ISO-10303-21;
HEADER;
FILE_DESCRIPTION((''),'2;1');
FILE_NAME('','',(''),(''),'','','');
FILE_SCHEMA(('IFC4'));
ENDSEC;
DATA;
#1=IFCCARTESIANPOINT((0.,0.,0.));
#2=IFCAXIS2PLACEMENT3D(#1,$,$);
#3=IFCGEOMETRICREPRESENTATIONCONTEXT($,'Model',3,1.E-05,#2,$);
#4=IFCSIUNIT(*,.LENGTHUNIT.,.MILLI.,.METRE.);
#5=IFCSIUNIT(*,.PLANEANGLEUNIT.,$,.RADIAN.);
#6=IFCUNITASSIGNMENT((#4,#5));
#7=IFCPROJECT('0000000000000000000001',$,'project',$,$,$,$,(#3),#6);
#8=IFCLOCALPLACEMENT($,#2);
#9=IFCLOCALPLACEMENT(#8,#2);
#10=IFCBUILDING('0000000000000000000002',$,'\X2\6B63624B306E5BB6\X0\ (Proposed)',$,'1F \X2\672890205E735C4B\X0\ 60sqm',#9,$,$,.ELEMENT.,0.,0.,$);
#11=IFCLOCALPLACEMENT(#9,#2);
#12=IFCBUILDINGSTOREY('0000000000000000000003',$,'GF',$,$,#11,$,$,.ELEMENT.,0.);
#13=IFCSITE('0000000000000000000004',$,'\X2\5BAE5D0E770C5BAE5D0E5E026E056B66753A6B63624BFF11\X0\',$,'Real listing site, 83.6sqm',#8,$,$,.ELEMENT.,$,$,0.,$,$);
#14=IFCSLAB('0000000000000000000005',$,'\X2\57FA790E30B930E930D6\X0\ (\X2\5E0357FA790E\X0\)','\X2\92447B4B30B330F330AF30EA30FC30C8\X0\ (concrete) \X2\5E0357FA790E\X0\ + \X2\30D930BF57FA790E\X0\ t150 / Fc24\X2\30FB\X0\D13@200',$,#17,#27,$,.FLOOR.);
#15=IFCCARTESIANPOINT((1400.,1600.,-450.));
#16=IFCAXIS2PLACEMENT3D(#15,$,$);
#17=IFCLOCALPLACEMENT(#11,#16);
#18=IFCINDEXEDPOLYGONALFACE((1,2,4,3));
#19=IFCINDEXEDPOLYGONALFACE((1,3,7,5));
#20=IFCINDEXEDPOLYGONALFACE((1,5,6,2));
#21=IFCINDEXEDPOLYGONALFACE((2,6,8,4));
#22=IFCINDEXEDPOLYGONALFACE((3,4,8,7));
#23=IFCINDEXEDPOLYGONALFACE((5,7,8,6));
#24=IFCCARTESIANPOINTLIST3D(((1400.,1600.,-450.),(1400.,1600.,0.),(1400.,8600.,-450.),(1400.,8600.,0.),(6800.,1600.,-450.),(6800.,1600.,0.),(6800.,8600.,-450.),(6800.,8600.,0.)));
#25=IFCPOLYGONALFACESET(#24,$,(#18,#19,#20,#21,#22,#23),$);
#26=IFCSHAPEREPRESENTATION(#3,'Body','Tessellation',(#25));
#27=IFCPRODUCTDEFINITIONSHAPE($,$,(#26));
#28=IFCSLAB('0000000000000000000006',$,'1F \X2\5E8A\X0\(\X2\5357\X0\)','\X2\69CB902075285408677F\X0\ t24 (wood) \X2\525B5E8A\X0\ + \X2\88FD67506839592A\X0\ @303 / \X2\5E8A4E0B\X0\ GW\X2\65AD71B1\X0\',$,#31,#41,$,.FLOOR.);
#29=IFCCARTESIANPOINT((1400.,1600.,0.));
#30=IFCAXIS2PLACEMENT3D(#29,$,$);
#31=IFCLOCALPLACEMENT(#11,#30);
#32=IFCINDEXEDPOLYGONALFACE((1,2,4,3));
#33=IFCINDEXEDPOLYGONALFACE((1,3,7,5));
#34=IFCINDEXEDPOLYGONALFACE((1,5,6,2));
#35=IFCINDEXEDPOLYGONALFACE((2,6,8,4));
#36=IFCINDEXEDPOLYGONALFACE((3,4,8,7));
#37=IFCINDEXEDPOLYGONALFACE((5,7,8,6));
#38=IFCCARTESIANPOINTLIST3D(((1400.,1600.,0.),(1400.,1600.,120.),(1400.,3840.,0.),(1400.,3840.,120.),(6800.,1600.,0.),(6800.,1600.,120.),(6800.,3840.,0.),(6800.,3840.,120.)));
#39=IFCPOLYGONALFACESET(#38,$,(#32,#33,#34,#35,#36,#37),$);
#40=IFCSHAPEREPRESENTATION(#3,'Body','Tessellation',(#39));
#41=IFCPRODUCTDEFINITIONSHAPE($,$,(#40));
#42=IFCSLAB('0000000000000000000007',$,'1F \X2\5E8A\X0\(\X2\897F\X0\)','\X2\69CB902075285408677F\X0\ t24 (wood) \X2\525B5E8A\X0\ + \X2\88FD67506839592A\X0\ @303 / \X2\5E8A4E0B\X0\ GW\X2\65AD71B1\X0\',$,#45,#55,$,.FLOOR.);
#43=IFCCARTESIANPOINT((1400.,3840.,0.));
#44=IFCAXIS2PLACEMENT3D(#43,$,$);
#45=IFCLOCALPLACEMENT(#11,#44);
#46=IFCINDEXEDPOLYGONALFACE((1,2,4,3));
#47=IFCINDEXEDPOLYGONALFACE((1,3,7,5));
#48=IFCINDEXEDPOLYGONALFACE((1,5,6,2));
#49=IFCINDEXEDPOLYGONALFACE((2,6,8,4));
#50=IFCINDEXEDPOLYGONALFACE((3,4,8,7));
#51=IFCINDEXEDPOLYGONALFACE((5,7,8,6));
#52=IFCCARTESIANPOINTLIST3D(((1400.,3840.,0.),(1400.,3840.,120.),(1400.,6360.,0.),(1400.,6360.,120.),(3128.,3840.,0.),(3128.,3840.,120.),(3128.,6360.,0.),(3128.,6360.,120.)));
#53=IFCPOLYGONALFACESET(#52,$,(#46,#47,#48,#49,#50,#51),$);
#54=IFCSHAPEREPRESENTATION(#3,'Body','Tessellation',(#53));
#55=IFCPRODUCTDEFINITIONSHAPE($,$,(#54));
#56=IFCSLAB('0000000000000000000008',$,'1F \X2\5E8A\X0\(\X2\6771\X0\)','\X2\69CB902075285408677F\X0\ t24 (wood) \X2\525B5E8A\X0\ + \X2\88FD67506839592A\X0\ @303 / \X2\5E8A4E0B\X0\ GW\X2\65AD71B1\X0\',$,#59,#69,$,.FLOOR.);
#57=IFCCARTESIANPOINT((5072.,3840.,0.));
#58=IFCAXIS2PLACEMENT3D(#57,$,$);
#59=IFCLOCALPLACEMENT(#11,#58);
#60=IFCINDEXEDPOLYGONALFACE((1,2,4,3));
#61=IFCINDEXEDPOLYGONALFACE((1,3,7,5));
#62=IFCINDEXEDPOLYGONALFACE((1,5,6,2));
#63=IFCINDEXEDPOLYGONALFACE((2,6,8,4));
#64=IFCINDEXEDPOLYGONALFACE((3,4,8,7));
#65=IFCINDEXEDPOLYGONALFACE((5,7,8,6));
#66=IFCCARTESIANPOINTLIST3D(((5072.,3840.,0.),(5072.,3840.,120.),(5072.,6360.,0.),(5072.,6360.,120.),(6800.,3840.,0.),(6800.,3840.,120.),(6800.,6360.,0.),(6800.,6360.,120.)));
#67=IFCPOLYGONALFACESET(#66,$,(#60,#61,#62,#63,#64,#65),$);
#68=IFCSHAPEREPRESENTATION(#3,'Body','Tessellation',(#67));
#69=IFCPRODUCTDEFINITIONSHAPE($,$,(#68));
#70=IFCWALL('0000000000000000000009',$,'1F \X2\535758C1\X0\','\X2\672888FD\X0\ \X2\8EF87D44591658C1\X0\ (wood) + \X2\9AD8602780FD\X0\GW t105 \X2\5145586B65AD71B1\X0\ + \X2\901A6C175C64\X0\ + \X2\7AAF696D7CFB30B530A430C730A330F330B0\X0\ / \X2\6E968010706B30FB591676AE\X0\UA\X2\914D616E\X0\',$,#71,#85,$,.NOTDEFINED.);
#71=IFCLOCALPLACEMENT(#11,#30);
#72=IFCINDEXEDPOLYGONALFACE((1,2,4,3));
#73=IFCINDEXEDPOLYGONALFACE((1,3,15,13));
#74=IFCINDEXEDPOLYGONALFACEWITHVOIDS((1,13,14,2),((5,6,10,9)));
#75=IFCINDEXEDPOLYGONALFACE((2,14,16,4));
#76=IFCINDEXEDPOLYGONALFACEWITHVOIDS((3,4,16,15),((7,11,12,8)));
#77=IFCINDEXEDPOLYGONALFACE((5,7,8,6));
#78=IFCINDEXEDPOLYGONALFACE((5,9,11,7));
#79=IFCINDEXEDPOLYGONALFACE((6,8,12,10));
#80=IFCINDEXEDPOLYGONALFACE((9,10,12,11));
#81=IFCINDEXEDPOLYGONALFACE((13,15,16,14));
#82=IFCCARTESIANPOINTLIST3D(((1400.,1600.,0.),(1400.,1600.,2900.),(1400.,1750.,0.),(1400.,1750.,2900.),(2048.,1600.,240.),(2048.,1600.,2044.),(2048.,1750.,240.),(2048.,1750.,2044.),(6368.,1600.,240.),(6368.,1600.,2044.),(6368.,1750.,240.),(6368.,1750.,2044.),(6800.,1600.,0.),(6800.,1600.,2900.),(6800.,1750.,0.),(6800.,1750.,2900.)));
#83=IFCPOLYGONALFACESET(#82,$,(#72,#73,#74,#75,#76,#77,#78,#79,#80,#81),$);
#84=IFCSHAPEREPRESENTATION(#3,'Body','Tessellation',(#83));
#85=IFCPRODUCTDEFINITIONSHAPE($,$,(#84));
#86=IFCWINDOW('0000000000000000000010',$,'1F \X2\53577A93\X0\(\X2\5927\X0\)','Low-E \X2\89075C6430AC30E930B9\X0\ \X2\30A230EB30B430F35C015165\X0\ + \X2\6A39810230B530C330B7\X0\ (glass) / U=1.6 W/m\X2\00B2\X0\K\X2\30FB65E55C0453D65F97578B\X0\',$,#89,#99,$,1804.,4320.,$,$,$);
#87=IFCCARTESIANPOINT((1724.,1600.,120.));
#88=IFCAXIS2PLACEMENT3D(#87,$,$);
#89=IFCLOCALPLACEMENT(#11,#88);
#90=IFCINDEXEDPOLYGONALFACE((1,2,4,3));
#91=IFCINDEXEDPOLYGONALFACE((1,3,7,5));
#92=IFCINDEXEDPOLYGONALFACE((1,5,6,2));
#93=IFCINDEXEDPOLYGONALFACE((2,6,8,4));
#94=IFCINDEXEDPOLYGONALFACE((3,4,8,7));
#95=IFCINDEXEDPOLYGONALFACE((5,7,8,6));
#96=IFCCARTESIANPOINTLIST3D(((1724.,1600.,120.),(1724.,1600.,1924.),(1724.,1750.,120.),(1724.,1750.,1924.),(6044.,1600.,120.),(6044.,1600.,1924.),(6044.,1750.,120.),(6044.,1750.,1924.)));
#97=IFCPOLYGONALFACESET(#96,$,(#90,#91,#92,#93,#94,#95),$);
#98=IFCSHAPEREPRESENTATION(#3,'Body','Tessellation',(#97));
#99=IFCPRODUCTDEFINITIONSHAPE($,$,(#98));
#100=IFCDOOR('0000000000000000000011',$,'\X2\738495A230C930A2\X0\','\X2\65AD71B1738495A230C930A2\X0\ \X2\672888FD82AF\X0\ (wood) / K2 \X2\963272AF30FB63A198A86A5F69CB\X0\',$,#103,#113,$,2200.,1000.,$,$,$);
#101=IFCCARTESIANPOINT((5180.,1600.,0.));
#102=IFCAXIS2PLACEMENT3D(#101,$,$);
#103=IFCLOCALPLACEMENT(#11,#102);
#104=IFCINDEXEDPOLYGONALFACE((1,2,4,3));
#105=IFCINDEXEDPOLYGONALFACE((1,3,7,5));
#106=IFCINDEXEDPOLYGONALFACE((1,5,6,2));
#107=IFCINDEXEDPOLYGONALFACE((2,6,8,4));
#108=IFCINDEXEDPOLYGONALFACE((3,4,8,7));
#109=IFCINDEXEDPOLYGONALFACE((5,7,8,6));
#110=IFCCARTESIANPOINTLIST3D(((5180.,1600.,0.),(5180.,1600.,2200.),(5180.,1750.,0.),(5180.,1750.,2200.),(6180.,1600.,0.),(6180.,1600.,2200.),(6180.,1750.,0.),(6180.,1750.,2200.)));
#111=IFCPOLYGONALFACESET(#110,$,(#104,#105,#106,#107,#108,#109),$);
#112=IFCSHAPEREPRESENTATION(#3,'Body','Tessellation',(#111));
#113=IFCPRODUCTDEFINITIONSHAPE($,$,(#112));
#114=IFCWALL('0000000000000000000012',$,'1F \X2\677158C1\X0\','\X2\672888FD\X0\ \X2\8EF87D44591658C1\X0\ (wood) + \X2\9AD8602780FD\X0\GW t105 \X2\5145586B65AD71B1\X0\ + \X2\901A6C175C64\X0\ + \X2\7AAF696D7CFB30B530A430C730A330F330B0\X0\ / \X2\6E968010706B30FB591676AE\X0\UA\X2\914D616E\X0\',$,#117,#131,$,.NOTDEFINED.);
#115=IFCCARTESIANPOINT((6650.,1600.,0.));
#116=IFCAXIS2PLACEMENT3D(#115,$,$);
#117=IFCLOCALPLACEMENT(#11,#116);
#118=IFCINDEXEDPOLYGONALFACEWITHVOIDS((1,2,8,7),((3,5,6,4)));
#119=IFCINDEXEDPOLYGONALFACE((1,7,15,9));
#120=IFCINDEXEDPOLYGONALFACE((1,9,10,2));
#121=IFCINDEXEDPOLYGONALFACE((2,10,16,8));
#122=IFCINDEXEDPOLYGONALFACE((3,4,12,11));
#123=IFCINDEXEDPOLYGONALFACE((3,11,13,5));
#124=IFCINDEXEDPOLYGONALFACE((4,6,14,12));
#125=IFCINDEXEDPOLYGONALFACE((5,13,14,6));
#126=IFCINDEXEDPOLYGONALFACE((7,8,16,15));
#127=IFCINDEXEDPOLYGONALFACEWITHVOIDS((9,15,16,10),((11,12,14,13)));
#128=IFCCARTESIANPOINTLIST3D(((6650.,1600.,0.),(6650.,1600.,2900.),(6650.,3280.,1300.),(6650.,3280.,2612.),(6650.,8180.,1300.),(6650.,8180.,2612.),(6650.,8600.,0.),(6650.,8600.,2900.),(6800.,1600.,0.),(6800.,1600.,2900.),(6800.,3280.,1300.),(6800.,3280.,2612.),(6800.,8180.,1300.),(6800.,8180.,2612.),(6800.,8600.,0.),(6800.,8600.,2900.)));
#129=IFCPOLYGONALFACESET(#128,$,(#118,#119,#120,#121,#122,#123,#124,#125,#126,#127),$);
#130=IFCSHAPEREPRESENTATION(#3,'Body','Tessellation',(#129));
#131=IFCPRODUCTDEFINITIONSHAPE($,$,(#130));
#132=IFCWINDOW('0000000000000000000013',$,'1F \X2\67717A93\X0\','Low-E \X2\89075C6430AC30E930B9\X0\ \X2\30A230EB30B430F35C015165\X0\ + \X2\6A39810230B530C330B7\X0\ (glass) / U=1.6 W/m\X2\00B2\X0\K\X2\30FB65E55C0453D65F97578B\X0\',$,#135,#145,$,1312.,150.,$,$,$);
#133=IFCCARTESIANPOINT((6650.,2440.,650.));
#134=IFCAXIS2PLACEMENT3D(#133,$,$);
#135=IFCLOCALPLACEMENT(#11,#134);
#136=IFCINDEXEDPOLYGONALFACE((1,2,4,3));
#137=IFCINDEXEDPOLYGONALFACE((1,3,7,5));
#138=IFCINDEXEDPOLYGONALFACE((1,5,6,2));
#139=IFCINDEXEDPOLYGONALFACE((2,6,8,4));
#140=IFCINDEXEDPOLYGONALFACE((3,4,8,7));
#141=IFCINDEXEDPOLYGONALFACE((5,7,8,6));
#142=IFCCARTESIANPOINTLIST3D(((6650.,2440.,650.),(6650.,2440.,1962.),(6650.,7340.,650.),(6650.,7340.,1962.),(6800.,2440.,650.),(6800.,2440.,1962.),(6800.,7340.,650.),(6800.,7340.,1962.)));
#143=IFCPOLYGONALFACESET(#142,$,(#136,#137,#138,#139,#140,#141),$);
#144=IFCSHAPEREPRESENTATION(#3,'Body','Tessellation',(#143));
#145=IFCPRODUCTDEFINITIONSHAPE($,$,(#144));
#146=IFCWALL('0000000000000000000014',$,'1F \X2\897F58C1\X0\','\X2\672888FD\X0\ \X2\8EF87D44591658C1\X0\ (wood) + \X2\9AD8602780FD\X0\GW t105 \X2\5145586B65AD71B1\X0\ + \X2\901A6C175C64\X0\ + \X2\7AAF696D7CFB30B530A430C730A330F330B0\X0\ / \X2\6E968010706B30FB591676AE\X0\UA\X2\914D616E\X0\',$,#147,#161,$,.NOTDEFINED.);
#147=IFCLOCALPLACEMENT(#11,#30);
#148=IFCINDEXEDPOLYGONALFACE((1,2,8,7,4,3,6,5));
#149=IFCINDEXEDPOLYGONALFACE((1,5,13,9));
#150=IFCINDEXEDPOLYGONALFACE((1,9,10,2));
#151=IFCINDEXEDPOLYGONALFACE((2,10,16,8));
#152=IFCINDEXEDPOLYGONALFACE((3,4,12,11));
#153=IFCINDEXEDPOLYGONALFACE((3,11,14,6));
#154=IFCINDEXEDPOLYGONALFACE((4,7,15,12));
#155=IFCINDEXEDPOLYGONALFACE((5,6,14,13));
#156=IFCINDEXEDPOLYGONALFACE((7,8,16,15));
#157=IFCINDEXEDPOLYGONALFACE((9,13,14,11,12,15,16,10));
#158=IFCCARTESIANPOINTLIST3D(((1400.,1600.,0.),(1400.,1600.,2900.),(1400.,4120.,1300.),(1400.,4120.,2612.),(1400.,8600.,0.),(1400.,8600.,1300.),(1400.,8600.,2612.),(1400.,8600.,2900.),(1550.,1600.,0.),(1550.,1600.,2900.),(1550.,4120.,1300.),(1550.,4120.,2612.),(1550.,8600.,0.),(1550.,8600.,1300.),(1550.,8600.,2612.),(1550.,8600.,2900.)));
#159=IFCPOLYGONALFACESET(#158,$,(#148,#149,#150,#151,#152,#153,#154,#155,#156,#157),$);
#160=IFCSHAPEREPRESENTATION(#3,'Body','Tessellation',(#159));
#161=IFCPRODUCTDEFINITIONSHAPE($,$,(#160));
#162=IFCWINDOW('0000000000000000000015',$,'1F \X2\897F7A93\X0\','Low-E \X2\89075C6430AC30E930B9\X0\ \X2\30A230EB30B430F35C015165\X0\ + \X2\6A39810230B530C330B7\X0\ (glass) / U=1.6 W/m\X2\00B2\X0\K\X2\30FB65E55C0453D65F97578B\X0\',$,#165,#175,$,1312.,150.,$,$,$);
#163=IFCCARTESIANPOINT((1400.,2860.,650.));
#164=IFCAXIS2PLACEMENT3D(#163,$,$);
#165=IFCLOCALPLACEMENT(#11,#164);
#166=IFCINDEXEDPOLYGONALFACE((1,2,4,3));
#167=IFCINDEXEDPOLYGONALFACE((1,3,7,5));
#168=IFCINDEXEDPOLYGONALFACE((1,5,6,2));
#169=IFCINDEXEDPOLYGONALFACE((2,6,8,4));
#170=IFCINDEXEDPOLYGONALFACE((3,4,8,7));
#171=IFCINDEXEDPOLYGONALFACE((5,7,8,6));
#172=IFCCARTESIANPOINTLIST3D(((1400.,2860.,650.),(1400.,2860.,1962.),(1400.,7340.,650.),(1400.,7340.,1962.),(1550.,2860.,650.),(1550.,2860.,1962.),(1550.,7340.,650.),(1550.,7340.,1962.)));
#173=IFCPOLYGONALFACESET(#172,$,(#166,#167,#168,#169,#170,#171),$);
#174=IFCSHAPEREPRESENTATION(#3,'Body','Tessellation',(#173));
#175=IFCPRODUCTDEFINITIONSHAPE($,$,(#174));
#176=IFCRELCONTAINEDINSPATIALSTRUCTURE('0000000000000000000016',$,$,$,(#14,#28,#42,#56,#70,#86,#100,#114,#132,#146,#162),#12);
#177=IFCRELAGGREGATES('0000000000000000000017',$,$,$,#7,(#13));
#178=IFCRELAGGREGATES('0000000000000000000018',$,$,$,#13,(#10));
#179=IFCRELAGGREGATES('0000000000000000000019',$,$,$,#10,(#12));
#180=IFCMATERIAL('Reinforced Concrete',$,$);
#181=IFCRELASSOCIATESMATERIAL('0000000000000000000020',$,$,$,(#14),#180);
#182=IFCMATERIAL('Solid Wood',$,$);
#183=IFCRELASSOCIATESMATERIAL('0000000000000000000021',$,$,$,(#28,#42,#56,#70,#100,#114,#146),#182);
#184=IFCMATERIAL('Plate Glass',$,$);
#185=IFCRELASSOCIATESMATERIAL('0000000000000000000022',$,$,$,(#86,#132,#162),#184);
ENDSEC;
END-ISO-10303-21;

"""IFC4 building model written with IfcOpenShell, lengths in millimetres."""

from ifc_helpers import new_model, si_unit, frame, frame_2d, origin, place, context, project, spatial, rectangle, extrude, material, element, fill, save


model = new_model("IFC4")

# Units and contexts
model_context = context("Model", 3, precision=1e-05, world=origin())
ifc_project = project(units=[si_unit("LENGTHUNIT", "METRE", prefix="MILLI"), si_unit("PLANEANGLEUNIT", "RADIAN")], contexts=[model_context])

# Site, building, storey
site_placement = place(None, origin())
site = spatial("IfcSite", under=ifc_project, at=site_placement, Name="宮崎県宮崎市清武町正手１", ObjectType="Real listing site, 83.6sqm", CompositionType="ELEMENT", RefElevation=0.0)
building_placement = place(site_placement, origin())
building = spatial("IfcBuilding", under=site, at=building_placement, Name="正手の家 (Proposed)", ObjectType="1F 木造平屋 60sqm", CompositionType="ELEMENT", ElevationOfRefHeight=0.0, ElevationOfTerrain=0.0)
storey_placement = place(building_placement, origin())
storey = spatial("IfcBuildingStorey", under=building, at=storey_placement, Name="GF", CompositionType="ELEMENT", Elevation=0.0)

# Slabs
ifc_material_1 = material(Name="Reinforced Concrete")
slab_1_placement = place(storey_placement, frame((1400.0, 1600.0, -450.0)))
element("IfcSlab", 1, at=slab_1_placement, inside=storey, material=ifc_material_1, Name="基礎スラブ (布基礎)", Description="鉄筋コンクリート (concrete) 布基礎 + ベタ基礎 t150 / Fc24・D13@200", PredefinedType="FLOOR", context=model_context, shape_type="SweptSolid", body=[
    extrude(rectangle(XDim=5400.0, YDim=7000.0, at=frame_2d((2700.0, 3500.0))), frame((1400.0, 1600.0, -450.0)), (0.0, 0.0, 1.0), 450.0),
])
ifc_material_2 = material(Name="Solid Wood")
slab_2_placement = place(storey_placement, frame((1400.0, 1600.0, 0.0)))
element("IfcSlab", 2, at=slab_2_placement, inside=storey, material=ifc_material_2, Name="1F 床(南)", Description="構造用合板 t24 (wood) 剛床 + 製材根太 @303 / 床下 GW断熱", PredefinedType="FLOOR", context=model_context, shape_type="SweptSolid", body=[
    extrude(rectangle(XDim=5400.0, YDim=2240.0, at=frame_2d((2700.0, 1120.0))), frame((1400.0, 1600.0, 0.0)), (0.0, 0.0, 1.0), 120.0),
])
slab_3_placement = place(storey_placement, frame((1400.0, 3840.0, 0.0)))
element("IfcSlab", 3, at=slab_3_placement, inside=storey, material=ifc_material_2, Name="1F 床(西)", Description="構造用合板 t24 (wood) 剛床 + 製材根太 @303 / 床下 GW断熱", PredefinedType="FLOOR", context=model_context, shape_type="SweptSolid", body=[
    extrude(rectangle(XDim=1728.0, YDim=2520.0, at=frame_2d((864.0, 1260.0))), frame((1400.0, 3840.0, 0.0)), (0.0, 0.0, 1.0), 120.0),
])
slab_4_placement = place(storey_placement, frame((5072.0, 3840.0, 0.0)))
element("IfcSlab", 4, at=slab_4_placement, inside=storey, material=ifc_material_2, Name="1F 床(東)", Description="構造用合板 t24 (wood) 剛床 + 製材根太 @303 / 床下 GW断熱", PredefinedType="FLOOR", context=model_context, shape_type="SweptSolid", body=[
    extrude(rectangle(XDim=1728.0, YDim=2520.0, at=frame_2d((864.0, 1260.0))), frame((5072.0, 3840.0, 0.0)), (0.0, 0.0, 1.0), 120.0),
])

# Wall, openings, window, door
wall_1_placement = place(storey_placement, frame((1400.0, 1600.0, 0.0)))
wall_1 = element("IfcWall", 5, at=wall_1_placement, inside=storey, material=ifc_material_2, Name="1F 南壁", Description="木製 軸組外壁 (wood) + 高性能GW t105 充填断熱 + 通気層 + 窯業系サイディング / 準耐火・外皮UA配慮", PredefinedType="NOTDEFINED", context=model_context, shape_type="SweptSolid", body=[
    extrude(rectangle(XDim=5400.0, YDim=150.0, at=frame_2d((2700.0, 75.0))), frame((1400.0, 1600.0, 0.0)), (0.0, 0.0, 1.0), 2900.0),
])
opening_1_placement = place(storey_placement, frame((1724.0, 1600.0, 120.0)))
opening_1 = element("IfcOpeningElement", 6, at=opening_1_placement, cuts=wall_1, PredefinedType="NOTDEFINED", context=model_context, shape_type="SweptSolid", body=[
    extrude(rectangle(XDim=4320.0, YDim=150.0, at=frame_2d((2160.0, 75.0))), frame((1724.0, 1600.0, 120.0)), (0.0, 0.0, 1.0), 1804.0),
])
opening_2_placement = place(storey_placement, frame((5180.0, 1600.0, 0.0)))
opening_2 = element("IfcOpeningElement", 7, at=opening_2_placement, cuts=wall_1, PredefinedType="NOTDEFINED", context=model_context, shape_type="SweptSolid", body=[
    extrude(rectangle(XDim=1000.0, YDim=150.0, at=frame_2d((500.0, 75.0))), frame((5180.0, 1600.0, 0.0)), (0.0, 0.0, 1.0), 2200.0),
])
ifc_material_3 = material(Name="Plate Glass")
window_1_placement = place(storey_placement, frame((1724.0, 1600.0, 120.0)))
window_1 = element("IfcWindow", 8, at=window_1_placement, inside=storey, material=ifc_material_3, Name="1F 南窓(大)", Description="Low-E 複層ガラス アルゴン封入 + 樹脂サッシ (glass) / U=1.6 W/m²K・日射取得型", OverallHeight=1804.0, OverallWidth=4320.0, context=model_context, shape_type="SweptSolid", body=[
    extrude(rectangle(XDim=4320.0, YDim=150.0, at=frame_2d((2160.0, 75.0))), frame((1724.0, 1600.0, 120.0)), (0.0, 0.0, 1.0), 1804.0),
])
fill(opening_1, window_1)
door_placement = place(storey_placement, frame((5180.0, 1600.0, 0.0)))
door = element("IfcDoor", 9, at=door_placement, inside=storey, material=ifc_material_2, Name="玄関ドア", Description="断熱玄関ドア 木製芯 (wood) / K2 防犯・採風機構", OverallHeight=2200.0, OverallWidth=1000.0, context=model_context, shape_type="SweptSolid", body=[
    extrude(rectangle(XDim=1000.0, YDim=150.0, at=frame_2d((500.0, 75.0))), frame((5180.0, 1600.0, 0.0)), (0.0, 0.0, 1.0), 2200.0),
])
fill(opening_2, door)

# Walls, openings, windows
wall_2_placement = place(storey_placement, frame((6650.0, 1600.0, 0.0)))
wall_2 = element("IfcWall", 10, at=wall_2_placement, inside=storey, material=ifc_material_2, Name="1F 東壁", Description="木製 軸組外壁 (wood) + 高性能GW t105 充填断熱 + 通気層 + 窯業系サイディング / 準耐火・外皮UA配慮", PredefinedType="NOTDEFINED", context=model_context, shape_type="SweptSolid", body=[
    extrude(rectangle(XDim=150.0, YDim=7000.0, at=frame_2d((75.0, 3500.0))), frame((6650.0, 1600.0, 0.0)), (0.0, 0.0, 1.0), 2900.0),
])
opening_3_placement = place(storey_placement, frame((6650.0, 2440.0, 650.0)))
opening_3 = element("IfcOpeningElement", 11, at=opening_3_placement, cuts=wall_2, PredefinedType="NOTDEFINED", context=model_context, shape_type="SweptSolid", body=[
    extrude(rectangle(XDim=150.0, YDim=4900.0, at=frame_2d((75.0, 2450.0))), frame((6650.0, 2440.0, 650.0)), (0.0, 0.0, 1.0), 1312.0),
])
window_2_placement = place(storey_placement, frame((6650.0, 2440.0, 650.0)))
window_2 = element("IfcWindow", 12, at=window_2_placement, inside=storey, material=ifc_material_3, Name="1F 東窓", Description="Low-E 複層ガラス アルゴン封入 + 樹脂サッシ (glass) / U=1.6 W/m²K・日射取得型", OverallHeight=1312.0, OverallWidth=150.0, context=model_context, shape_type="SweptSolid", body=[
    extrude(rectangle(XDim=150.0, YDim=4900.0, at=frame_2d((75.0, 2450.0))), frame((6650.0, 2440.0, 650.0)), (0.0, 0.0, 1.0), 1312.0),
])
fill(opening_3, window_2)
wall_3_placement = place(storey_placement, frame((1400.0, 1600.0, 0.0)))
wall_3 = element("IfcWall", 13, at=wall_3_placement, inside=storey, material=ifc_material_2, Name="1F 西壁", Description="木製 軸組外壁 (wood) + 高性能GW t105 充填断熱 + 通気層 + 窯業系サイディング / 準耐火・外皮UA配慮", PredefinedType="NOTDEFINED", context=model_context, shape_type="SweptSolid", body=[
    extrude(rectangle(XDim=150.0, YDim=7000.0, at=frame_2d((75.0, 3500.0))), frame((1400.0, 1600.0, 0.0)), (0.0, 0.0, 1.0), 2900.0),
])
opening_4_placement = place(storey_placement, frame((1400.0, 2860.0, 650.0)))
opening_4 = element("IfcOpeningElement", 14, at=opening_4_placement, cuts=wall_3, PredefinedType="NOTDEFINED", context=model_context, shape_type="SweptSolid", body=[
    extrude(rectangle(XDim=150.0, YDim=4480.0, at=frame_2d((75.0, 2240.0))), frame((1400.0, 2860.0, 650.0)), (0.0, 0.0, 1.0), 1312.0),
])
window_3_placement = place(storey_placement, frame((1400.0, 2860.0, 650.0)))
window_3 = element("IfcWindow", 15, at=window_3_placement, inside=storey, material=ifc_material_3, Name="1F 西窓", Description="Low-E 複層ガラス アルゴン封入 + 樹脂サッシ (glass) / U=1.6 W/m²K・日射取得型", OverallHeight=1312.0, OverallWidth=150.0, context=model_context, shape_type="SweptSolid", body=[
    extrude(rectangle(XDim=150.0, YDim=4480.0, at=frame_2d((75.0, 2240.0))), frame((1400.0, 2860.0, 650.0)), (0.0, 0.0, 1.0), 1312.0),
])
fill(opening_4, window_3)

save(model, "model.ifc")
